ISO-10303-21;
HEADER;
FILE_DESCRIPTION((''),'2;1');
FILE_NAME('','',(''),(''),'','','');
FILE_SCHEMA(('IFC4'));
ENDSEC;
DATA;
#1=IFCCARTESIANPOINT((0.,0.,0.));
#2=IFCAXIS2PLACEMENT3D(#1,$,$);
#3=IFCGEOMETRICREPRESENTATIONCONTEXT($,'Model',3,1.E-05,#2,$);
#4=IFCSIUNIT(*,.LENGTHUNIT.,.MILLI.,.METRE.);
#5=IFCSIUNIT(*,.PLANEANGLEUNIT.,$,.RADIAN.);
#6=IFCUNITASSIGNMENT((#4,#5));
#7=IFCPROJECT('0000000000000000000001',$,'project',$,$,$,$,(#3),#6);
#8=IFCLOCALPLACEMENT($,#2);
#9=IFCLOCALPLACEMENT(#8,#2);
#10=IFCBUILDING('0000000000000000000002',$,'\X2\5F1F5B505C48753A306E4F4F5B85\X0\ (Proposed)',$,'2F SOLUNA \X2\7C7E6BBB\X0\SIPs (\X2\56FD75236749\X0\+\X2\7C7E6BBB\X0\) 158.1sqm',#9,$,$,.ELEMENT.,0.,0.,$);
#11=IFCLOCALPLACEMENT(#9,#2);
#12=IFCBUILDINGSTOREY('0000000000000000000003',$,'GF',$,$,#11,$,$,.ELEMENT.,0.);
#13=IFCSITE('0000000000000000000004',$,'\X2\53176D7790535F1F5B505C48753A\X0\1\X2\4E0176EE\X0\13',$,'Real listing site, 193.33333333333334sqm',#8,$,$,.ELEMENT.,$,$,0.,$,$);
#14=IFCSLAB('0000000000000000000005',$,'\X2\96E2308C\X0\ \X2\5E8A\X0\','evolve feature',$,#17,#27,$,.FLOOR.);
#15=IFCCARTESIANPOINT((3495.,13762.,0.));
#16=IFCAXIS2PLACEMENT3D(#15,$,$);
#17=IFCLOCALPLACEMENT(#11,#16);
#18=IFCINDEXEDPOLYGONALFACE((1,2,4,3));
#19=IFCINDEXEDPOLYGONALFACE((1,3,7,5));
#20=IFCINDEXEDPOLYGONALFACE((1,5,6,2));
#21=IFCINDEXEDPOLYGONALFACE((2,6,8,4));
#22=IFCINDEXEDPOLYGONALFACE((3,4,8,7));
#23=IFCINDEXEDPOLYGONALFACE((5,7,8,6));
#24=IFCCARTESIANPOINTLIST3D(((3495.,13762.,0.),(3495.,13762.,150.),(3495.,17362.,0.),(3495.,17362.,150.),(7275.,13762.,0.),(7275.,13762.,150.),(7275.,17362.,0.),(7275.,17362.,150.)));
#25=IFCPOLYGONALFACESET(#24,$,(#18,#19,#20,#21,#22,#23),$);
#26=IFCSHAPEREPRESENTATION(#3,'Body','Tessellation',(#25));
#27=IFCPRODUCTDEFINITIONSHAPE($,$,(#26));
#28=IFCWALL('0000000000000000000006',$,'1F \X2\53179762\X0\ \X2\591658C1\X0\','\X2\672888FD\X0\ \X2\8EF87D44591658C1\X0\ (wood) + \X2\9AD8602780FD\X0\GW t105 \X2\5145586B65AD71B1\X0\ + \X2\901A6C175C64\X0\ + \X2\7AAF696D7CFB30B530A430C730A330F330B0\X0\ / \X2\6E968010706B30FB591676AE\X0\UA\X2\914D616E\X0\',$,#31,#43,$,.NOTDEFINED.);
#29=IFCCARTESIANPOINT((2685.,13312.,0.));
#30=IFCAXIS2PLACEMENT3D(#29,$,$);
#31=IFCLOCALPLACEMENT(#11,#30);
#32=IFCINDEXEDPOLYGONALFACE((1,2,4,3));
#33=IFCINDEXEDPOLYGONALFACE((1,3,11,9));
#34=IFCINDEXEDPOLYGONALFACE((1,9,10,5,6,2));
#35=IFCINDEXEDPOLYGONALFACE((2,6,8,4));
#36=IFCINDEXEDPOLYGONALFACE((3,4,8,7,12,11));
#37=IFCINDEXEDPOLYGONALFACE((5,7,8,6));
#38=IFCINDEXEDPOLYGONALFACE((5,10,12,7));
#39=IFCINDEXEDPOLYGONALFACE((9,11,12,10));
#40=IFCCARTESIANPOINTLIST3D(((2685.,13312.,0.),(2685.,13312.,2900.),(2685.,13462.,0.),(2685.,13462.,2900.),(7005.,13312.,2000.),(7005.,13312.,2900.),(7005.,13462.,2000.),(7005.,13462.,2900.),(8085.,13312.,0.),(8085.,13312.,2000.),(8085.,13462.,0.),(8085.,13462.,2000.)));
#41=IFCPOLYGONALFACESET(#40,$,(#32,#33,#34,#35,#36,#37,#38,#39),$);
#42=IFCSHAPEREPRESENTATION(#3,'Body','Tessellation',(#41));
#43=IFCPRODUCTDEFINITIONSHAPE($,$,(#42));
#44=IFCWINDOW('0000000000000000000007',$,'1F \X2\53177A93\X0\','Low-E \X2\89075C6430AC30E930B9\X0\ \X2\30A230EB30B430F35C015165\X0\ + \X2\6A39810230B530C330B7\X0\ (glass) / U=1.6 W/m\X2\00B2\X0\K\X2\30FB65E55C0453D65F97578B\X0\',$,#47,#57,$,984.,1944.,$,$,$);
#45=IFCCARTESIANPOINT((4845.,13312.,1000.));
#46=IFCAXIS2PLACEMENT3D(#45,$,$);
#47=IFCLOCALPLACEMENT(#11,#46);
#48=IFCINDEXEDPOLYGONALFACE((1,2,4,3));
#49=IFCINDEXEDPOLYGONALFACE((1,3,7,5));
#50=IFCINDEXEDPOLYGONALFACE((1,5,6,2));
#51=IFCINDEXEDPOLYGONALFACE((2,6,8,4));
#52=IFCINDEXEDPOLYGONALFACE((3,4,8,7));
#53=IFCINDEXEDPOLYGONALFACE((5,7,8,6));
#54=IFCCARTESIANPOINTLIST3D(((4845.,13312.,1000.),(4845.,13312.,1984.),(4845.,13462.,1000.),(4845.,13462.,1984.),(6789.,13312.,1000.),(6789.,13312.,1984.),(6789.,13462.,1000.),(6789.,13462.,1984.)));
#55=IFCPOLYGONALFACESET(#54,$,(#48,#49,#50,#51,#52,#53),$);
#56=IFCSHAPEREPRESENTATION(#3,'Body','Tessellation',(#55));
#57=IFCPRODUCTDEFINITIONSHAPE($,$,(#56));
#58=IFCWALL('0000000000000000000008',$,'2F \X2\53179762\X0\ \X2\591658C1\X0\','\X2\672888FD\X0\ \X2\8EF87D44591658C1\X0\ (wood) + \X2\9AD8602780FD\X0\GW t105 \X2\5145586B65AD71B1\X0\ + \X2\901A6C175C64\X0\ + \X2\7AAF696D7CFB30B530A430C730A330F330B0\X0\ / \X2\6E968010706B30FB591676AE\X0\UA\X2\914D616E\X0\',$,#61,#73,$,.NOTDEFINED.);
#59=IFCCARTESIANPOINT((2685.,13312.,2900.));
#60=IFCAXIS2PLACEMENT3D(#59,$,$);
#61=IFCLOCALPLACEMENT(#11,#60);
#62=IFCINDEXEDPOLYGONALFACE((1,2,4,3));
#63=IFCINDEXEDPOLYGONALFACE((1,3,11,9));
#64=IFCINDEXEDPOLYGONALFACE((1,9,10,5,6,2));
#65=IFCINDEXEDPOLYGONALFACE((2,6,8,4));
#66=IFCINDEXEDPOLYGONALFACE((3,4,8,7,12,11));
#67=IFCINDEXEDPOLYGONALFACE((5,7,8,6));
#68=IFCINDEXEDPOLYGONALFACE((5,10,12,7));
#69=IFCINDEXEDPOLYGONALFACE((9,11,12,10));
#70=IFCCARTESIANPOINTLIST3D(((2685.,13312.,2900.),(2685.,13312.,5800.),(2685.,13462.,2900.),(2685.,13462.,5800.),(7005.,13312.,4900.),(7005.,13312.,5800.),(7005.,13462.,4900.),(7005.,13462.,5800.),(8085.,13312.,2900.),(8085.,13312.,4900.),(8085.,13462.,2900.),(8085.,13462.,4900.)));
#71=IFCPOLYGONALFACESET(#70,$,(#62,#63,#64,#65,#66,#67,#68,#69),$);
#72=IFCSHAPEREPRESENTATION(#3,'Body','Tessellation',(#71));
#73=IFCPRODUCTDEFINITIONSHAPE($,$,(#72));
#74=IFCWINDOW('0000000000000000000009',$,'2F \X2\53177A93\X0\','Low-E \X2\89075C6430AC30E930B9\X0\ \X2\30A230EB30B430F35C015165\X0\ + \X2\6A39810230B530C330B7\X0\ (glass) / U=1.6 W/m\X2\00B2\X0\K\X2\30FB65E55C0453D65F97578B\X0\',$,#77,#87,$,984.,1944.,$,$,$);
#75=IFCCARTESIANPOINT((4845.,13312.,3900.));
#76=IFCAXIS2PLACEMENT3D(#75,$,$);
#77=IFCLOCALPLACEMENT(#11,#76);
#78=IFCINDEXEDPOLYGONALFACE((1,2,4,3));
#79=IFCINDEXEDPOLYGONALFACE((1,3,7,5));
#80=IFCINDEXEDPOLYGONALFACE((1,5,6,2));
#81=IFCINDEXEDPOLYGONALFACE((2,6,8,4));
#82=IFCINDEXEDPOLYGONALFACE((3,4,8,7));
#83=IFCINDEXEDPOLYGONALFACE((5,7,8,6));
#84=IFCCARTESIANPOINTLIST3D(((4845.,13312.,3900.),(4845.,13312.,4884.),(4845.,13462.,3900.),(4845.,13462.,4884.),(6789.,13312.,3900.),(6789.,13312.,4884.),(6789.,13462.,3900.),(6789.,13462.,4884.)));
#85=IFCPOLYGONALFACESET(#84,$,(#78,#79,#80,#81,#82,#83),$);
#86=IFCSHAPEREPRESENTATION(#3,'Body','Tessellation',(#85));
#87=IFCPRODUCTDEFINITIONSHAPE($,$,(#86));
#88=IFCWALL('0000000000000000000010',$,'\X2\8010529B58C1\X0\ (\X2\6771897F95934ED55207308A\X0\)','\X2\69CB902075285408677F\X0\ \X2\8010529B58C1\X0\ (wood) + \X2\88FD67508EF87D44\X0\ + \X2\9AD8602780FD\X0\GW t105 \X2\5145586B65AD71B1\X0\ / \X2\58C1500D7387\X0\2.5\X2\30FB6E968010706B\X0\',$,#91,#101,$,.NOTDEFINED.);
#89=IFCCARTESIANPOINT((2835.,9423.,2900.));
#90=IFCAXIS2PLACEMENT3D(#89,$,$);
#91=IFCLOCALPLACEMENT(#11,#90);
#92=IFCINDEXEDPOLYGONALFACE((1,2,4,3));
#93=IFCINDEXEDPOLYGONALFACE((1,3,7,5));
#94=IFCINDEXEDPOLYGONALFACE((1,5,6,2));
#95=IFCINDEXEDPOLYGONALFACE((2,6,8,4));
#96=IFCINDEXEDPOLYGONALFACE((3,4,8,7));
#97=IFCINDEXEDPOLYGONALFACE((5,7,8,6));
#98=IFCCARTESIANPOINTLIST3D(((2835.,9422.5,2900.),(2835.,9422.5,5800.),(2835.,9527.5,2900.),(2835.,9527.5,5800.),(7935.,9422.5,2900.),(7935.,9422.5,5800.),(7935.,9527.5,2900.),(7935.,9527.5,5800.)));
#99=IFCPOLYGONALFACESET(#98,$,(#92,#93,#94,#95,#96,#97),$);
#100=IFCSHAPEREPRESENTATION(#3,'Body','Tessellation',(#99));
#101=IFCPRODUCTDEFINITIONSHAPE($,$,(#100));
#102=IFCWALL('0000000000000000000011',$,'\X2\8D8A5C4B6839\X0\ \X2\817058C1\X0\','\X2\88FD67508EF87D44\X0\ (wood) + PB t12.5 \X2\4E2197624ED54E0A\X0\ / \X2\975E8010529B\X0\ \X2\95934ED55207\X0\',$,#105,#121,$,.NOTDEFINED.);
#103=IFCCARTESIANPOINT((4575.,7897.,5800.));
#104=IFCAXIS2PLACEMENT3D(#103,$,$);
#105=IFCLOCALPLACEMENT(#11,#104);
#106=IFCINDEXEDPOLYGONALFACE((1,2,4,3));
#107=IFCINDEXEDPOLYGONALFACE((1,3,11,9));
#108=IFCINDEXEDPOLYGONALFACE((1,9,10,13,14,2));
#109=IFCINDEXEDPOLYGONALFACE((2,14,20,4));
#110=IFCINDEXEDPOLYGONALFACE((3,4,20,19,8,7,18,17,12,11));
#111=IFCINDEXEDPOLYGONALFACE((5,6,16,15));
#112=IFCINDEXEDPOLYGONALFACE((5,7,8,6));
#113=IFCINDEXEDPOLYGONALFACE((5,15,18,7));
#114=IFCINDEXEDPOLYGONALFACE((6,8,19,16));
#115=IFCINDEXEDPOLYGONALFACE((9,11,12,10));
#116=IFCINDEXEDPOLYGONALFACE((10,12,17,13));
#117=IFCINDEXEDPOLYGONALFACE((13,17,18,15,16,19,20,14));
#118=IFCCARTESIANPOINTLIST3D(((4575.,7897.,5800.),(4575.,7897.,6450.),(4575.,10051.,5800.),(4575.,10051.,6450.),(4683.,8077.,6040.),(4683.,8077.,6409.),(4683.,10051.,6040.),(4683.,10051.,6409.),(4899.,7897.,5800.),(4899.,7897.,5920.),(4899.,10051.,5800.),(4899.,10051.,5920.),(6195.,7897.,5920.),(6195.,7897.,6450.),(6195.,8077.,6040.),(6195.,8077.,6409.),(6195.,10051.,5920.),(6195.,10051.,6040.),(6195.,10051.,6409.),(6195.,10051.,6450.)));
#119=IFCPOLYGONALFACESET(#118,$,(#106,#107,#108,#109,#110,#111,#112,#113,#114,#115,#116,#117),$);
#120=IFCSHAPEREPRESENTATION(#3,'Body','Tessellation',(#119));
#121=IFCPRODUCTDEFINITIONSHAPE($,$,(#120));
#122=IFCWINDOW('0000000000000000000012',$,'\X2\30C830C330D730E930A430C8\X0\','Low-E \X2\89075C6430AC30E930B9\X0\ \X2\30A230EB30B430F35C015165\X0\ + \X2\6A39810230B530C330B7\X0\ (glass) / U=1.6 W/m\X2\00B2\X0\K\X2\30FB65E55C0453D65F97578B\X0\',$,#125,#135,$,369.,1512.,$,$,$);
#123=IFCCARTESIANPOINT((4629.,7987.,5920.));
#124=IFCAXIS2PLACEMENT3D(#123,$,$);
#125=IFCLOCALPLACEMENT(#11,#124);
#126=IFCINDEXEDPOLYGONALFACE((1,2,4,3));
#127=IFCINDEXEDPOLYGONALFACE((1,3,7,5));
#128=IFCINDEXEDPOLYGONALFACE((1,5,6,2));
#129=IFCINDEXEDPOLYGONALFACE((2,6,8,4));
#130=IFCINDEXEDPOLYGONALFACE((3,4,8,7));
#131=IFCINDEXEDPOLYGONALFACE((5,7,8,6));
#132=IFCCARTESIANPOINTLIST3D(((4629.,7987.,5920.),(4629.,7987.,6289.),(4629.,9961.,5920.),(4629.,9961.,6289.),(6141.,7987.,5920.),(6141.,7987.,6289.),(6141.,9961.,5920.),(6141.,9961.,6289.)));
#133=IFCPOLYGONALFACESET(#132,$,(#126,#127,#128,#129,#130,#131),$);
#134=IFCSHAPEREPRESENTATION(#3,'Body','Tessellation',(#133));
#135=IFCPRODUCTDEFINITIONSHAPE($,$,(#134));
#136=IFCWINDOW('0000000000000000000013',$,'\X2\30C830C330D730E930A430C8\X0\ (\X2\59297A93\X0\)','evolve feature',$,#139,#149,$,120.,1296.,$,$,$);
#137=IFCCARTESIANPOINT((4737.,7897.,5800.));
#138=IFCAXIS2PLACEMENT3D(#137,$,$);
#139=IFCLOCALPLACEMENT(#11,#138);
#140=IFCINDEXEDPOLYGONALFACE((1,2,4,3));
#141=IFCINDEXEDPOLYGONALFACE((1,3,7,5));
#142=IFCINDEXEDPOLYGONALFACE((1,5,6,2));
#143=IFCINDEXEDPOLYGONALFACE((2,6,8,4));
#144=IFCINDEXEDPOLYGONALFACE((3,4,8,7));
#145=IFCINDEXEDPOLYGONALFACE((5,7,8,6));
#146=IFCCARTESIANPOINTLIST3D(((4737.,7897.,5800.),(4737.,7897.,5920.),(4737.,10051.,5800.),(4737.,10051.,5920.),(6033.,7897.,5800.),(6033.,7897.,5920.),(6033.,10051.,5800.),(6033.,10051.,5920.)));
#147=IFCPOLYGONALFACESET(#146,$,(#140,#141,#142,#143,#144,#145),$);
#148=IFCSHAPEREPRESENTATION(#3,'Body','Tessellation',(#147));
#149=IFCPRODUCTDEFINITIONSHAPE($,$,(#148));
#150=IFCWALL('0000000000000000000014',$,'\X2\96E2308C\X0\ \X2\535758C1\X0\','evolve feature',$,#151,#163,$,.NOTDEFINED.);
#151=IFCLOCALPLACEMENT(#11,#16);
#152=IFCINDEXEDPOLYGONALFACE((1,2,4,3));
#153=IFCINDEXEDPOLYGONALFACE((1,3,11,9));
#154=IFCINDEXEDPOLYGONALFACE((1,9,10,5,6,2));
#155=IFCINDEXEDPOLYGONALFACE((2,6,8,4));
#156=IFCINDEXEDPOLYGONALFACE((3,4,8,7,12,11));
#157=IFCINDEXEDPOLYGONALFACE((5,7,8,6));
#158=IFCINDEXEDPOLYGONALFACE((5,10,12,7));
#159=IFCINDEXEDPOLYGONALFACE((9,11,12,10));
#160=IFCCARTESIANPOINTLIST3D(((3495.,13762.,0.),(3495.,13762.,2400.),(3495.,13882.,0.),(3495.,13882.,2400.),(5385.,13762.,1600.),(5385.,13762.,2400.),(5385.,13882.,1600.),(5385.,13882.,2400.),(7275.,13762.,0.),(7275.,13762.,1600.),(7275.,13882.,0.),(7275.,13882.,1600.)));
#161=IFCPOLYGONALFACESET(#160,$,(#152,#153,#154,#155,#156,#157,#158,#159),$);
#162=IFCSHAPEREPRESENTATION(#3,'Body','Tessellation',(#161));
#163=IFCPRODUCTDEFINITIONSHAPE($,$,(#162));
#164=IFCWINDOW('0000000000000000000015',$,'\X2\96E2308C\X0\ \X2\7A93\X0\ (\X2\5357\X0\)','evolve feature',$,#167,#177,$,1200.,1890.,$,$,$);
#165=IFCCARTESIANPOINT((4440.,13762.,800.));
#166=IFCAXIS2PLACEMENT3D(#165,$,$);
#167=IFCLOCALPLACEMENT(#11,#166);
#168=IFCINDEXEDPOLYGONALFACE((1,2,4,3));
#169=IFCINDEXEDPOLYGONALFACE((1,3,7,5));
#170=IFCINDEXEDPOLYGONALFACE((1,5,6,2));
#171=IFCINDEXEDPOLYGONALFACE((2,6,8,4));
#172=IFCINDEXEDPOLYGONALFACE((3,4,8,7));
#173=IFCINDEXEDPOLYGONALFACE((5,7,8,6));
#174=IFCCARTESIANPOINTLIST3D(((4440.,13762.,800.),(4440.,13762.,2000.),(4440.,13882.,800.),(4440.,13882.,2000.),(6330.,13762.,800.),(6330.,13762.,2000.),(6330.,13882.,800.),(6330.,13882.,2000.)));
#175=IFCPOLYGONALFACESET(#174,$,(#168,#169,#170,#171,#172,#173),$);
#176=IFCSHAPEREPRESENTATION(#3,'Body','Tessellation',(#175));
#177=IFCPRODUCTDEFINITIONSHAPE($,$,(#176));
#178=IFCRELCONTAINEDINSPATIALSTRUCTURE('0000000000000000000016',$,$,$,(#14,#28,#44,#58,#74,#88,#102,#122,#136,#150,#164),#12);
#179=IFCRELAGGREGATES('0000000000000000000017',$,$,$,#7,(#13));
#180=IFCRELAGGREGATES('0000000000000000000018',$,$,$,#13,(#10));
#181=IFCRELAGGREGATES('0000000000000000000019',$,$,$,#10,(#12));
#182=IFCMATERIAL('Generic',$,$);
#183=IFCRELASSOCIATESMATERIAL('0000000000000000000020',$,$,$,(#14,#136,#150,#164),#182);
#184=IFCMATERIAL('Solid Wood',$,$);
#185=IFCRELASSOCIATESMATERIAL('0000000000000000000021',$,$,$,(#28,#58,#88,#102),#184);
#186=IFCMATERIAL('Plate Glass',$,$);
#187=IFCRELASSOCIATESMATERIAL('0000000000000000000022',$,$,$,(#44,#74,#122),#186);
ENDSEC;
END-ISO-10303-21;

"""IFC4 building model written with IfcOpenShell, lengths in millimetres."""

from ifc_helpers import new_model, si_unit, frame, frame_2d, origin, place, context, project, spatial, rectangle, extrude, material, element, fill, save


model = new_model("IFC4")

# Units and contexts
model_context = context("Model", 3, precision=1e-05, world=origin())
ifc_project = project(units=[si_unit("LENGTHUNIT", "METRE", prefix="MILLI"), si_unit("PLANEANGLEUNIT", "RADIAN")], contexts=[model_context])

# Site, building, storey
site_placement = place(None, origin())
site = spatial("IfcSite", under=ifc_project, at=site_placement, Name="北海道弟子屈町1丁目13", ObjectType="Real listing site, 193.33333333333334sqm", CompositionType="ELEMENT", RefElevation=0.0)
building_placement = place(site_placement, origin())
building = spatial("IfcBuilding", under=site, at=building_placement, Name="弟子屈町の住宅 (Proposed)", ObjectType="2F SOLUNA 籾殻SIPs (国産杉+籾殻) 158.1sqm", CompositionType="ELEMENT", ElevationOfRefHeight=0.0, ElevationOfTerrain=0.0)
storey_placement = place(building_placement, origin())
storey = spatial("IfcBuildingStorey", under=building, at=storey_placement, Name="GF", CompositionType="ELEMENT", Elevation=0.0)

# Slab
ifc_material_1 = material(Name="Generic")
slab_placement = place(storey_placement, frame((3495.0, 13762.0, 0.0)))
element("IfcSlab", 1, at=slab_placement, inside=storey, material=ifc_material_1, Name="離れ 床", Description="evolve feature", PredefinedType="FLOOR", context=model_context, shape_type="SweptSolid", body=[
    extrude(rectangle(XDim=3780.0, YDim=3600.0, at=frame_2d((1890.0, 1800.0))), frame((3495.0, 13762.0, 0.0)), (0.0, 0.0, 1.0), 150.0),
])

# Wall, opening, window
ifc_material_2 = material(Name="Solid Wood")
wall_1_placement = place(storey_placement, frame((2685.0, 13312.0, 0.0)))
wall_1 = element("IfcWall", 2, at=wall_1_placement, inside=storey, material=ifc_material_2, Name="1F 北面 外壁", Description="木製 軸組外壁 (wood) + 高性能GW t105 充填断熱 + 通気層 + 窯業系サイディング / 準耐火・外皮UA配慮", PredefinedType="NOTDEFINED", context=model_context, shape_type="SweptSolid", body=[
    extrude(rectangle(XDim=5400.0, YDim=150.0, at=frame_2d((2700.0, 75.0))), frame((2685.0, 13312.0, 0.0)), (0.0, 0.0, 1.0), 2900.0),
])
opening_1_placement = place(storey_placement, frame((4845.0, 13312.0, 1000.0)))
opening_1 = element("IfcOpeningElement", 3, at=opening_1_placement, cuts=wall_1, PredefinedType="NOTDEFINED", context=model_context, shape_type="SweptSolid", body=[
    extrude(rectangle(XDim=1944.0, YDim=150.0, at=frame_2d((972.0, 75.0))), frame((4845.0, 13312.0, 1000.0)), (0.0, 0.0, 1.0), 984.0),
])
ifc_material_3 = material(Name="Plate Glass")
window_1_placement = place(storey_placement, frame((4845.0, 13312.0, 1000.0)))
window_1 = element("IfcWindow", 4, at=window_1_placement, inside=storey, material=ifc_material_3, Name="1F 北窓", Description="Low-E 複層ガラス アルゴン封入 + 樹脂サッシ (glass) / U=1.6 W/m²K・日射取得型", OverallHeight=984.0, OverallWidth=1944.0, context=model_context, shape_type="SweptSolid", body=[
    extrude(rectangle(XDim=1944.0, YDim=150.0, at=frame_2d((972.0, 75.0))), frame((4845.0, 13312.0, 1000.0)), (0.0, 0.0, 1.0), 984.0),
])
fill(opening_1, window_1)

# Wall, opening, window
wall_2_placement = place(storey_placement, frame((2685.0, 13312.0, 2900.0)))
wall_2 = element("IfcWall", 5, at=wall_2_placement, inside=storey, material=ifc_material_2, Name="2F 北面 外壁", Description="木製 軸組外壁 (wood) + 高性能GW t105 充填断熱 + 通気層 + 窯業系サイディング / 準耐火・外皮UA配慮", PredefinedType="NOTDEFINED", context=model_context, shape_type="SweptSolid", body=[
    extrude(rectangle(XDim=5400.0, YDim=150.0, at=frame_2d((2700.0, 75.0))), frame((2685.0, 13312.0, 2900.0)), (0.0, 0.0, 1.0), 2900.0),
])
opening_2_placement = place(storey_placement, frame((4845.0, 13312.0, 3900.0)))
opening_2 = element("IfcOpeningElement", 6, at=opening_2_placement, cuts=wall_2, PredefinedType="NOTDEFINED", context=model_context, shape_type="SweptSolid", body=[
    extrude(rectangle(XDim=1944.0, YDim=150.0, at=frame_2d((972.0, 75.0))), frame((4845.0, 13312.0, 3900.0)), (0.0, 0.0, 1.0), 984.0),
])
window_2_placement = place(storey_placement, frame((4845.0, 13312.0, 3900.0)))
window_2 = element("IfcWindow", 7, at=window_2_placement, inside=storey, material=ifc_material_3, Name="2F 北窓", Description="Low-E 複層ガラス アルゴン封入 + 樹脂サッシ (glass) / U=1.6 W/m²K・日射取得型", OverallHeight=984.0, OverallWidth=1944.0, context=model_context, shape_type="SweptSolid", body=[
    extrude(rectangle(XDim=1944.0, YDim=150.0, at=frame_2d((972.0, 75.0))), frame((4845.0, 13312.0, 3900.0)), (0.0, 0.0, 1.0), 984.0),
])
fill(opening_2, window_2)

# Wall
wall_3_placement = place(storey_placement, frame((2835.0, 9423.0, 2900.0)))
element("IfcWall", 8, at=wall_3_placement, inside=storey, material=ifc_material_2, Name="耐力壁 (東西間仕切り)", Description="構造用合板 耐力壁 (wood) + 製材軸組 + 高性能GW t105 充填断熱 / 壁倍率2.5・準耐火", PredefinedType="NOTDEFINED", context=model_context, shape_type="SweptSolid", body=[
    extrude(rectangle(XDim=5100.0, YDim=105.0, at=frame_2d((2550.0, 52.0))), frame((2835.0, 9423.0, 2900.0)), (0.0, 0.0, 1.0), 2900.0),
])

# Wall, openings, windows
wall_4_placement = place(storey_placement, frame((4575.0, 7897.0, 5800.0)))
wall_4 = element("IfcWall", 9, at=wall_4_placement, inside=storey, material=ifc_material_2, Name="越屋根 腰壁", Description="製材軸組 (wood) + PB t12.5 両面仕上 / 非耐力 間仕切", PredefinedType="NOTDEFINED", context=model_context, shape_type="SweptSolid", body=[
    extrude(rectangle(XDim=1620.0, YDim=2154.0, at=frame_2d((810.0, 1077.0))), frame((4575.0, 7897.0, 5800.0)), (0.0, 0.0, 1.0), 650.0),
])
opening_3_placement = place(storey_placement, frame((4629.0, 7987.0, 5920.0)))
opening_3 = element("IfcOpeningElement", 10, at=opening_3_placement, cuts=wall_4, PredefinedType="NOTDEFINED", context=model_context, shape_type="SweptSolid", body=[
    extrude(rectangle(XDim=1512.0, YDim=1974.0, at=frame_2d((756.0, 987.0))), frame((4629.0, 7987.0, 5920.0)), (0.0, 0.0, 1.0), 369.0),
])
opening_4_placement = place(storey_placement, frame((4737.0, 7897.0, 5800.0)))
opening_4 = element("IfcOpeningElement", 11, at=opening_4_placement, cuts=wall_4, PredefinedType="NOTDEFINED", context=model_context, shape_type="SweptSolid", body=[
    extrude(rectangle(XDim=1296.0, YDim=2154.0, at=frame_2d((648.0, 1077.0))), frame((4737.0, 7897.0, 5800.0)), (0.0, 0.0, 1.0), 120.0),
])
window_3_placement = place(storey_placement, frame((4629.0, 7987.0, 5920.0)))
window_3 = element("IfcWindow", 12, at=window_3_placement, inside=storey, material=ifc_material_3, Name="トップライト", Description="Low-E 複層ガラス アルゴン封入 + 樹脂サッシ (glass) / U=1.6 W/m²K・日射取得型", OverallHeight=369.0, OverallWidth=1512.0, context=model_context, shape_type="SweptSolid", body=[
    extrude(rectangle(XDim=1512.0, YDim=1974.0, at=frame_2d((756.0, 987.0))), frame((4629.0, 7987.0, 5920.0)), (0.0, 0.0, 1.0), 369.0),
])
fill(opening_3, window_3)
window_4_placement = place(storey_placement, frame((4737.0, 7897.0, 5800.0)))
window_4 = element("IfcWindow", 13, at=window_4_placement, inside=storey, material=ifc_material_1, Name="トップライト (天窓)", Description="evolve feature", OverallHeight=120.0, OverallWidth=1296.0, context=model_context, shape_type="SweptSolid", body=[
    extrude(rectangle(XDim=1296.0, YDim=2154.0, at=frame_2d((648.0, 1077.0))), frame((4737.0, 7897.0, 5800.0)), (0.0, 0.0, 1.0), 120.0),
])
fill(opening_4, window_4)

# Wall, opening, window
wall_5_placement = place(storey_placement, frame((3495.0, 13762.0, 0.0)))
wall_5 = element("IfcWall", 14, at=wall_5_placement, inside=storey, material=ifc_material_1, Name="離れ 南壁", Description="evolve feature", PredefinedType="NOTDEFINED", context=model_context, shape_type="SweptSolid", body=[
    extrude(rectangle(XDim=3780.0, YDim=120.0, at=frame_2d((1890.0, 60.0))), frame((3495.0, 13762.0, 0.0)), (0.0, 0.0, 1.0), 2400.0),
])
opening_5_placement = place(storey_placement, frame((4440.0, 13762.0, 800.0)))
opening_5 = element("IfcOpeningElement", 15, at=opening_5_placement, cuts=wall_5, PredefinedType="NOTDEFINED", context=model_context, shape_type="SweptSolid", body=[
    extrude(rectangle(XDim=1890.0, YDim=120.0, at=frame_2d((945.0, 60.0))), frame((4440.0, 13762.0, 800.0)), (0.0, 0.0, 1.0), 1200.0),
])
window_5_placement = place(storey_placement, frame((4440.0, 13762.0, 800.0)))
window_5 = element("IfcWindow", 16, at=window_5_placement, inside=storey, material=ifc_material_1, Name="離れ 窓 (南)", Description="evolve feature", OverallHeight=1200.0, OverallWidth=1890.0, context=model_context, shape_type="SweptSolid", body=[
    extrude(rectangle(XDim=1890.0, YDim=120.0, at=frame_2d((945.0, 60.0))), frame((4440.0, 13762.0, 800.0)), (0.0, 0.0, 1.0), 1200.0),
])
fill(opening_5, window_5)

save(model, "model.ifc")
